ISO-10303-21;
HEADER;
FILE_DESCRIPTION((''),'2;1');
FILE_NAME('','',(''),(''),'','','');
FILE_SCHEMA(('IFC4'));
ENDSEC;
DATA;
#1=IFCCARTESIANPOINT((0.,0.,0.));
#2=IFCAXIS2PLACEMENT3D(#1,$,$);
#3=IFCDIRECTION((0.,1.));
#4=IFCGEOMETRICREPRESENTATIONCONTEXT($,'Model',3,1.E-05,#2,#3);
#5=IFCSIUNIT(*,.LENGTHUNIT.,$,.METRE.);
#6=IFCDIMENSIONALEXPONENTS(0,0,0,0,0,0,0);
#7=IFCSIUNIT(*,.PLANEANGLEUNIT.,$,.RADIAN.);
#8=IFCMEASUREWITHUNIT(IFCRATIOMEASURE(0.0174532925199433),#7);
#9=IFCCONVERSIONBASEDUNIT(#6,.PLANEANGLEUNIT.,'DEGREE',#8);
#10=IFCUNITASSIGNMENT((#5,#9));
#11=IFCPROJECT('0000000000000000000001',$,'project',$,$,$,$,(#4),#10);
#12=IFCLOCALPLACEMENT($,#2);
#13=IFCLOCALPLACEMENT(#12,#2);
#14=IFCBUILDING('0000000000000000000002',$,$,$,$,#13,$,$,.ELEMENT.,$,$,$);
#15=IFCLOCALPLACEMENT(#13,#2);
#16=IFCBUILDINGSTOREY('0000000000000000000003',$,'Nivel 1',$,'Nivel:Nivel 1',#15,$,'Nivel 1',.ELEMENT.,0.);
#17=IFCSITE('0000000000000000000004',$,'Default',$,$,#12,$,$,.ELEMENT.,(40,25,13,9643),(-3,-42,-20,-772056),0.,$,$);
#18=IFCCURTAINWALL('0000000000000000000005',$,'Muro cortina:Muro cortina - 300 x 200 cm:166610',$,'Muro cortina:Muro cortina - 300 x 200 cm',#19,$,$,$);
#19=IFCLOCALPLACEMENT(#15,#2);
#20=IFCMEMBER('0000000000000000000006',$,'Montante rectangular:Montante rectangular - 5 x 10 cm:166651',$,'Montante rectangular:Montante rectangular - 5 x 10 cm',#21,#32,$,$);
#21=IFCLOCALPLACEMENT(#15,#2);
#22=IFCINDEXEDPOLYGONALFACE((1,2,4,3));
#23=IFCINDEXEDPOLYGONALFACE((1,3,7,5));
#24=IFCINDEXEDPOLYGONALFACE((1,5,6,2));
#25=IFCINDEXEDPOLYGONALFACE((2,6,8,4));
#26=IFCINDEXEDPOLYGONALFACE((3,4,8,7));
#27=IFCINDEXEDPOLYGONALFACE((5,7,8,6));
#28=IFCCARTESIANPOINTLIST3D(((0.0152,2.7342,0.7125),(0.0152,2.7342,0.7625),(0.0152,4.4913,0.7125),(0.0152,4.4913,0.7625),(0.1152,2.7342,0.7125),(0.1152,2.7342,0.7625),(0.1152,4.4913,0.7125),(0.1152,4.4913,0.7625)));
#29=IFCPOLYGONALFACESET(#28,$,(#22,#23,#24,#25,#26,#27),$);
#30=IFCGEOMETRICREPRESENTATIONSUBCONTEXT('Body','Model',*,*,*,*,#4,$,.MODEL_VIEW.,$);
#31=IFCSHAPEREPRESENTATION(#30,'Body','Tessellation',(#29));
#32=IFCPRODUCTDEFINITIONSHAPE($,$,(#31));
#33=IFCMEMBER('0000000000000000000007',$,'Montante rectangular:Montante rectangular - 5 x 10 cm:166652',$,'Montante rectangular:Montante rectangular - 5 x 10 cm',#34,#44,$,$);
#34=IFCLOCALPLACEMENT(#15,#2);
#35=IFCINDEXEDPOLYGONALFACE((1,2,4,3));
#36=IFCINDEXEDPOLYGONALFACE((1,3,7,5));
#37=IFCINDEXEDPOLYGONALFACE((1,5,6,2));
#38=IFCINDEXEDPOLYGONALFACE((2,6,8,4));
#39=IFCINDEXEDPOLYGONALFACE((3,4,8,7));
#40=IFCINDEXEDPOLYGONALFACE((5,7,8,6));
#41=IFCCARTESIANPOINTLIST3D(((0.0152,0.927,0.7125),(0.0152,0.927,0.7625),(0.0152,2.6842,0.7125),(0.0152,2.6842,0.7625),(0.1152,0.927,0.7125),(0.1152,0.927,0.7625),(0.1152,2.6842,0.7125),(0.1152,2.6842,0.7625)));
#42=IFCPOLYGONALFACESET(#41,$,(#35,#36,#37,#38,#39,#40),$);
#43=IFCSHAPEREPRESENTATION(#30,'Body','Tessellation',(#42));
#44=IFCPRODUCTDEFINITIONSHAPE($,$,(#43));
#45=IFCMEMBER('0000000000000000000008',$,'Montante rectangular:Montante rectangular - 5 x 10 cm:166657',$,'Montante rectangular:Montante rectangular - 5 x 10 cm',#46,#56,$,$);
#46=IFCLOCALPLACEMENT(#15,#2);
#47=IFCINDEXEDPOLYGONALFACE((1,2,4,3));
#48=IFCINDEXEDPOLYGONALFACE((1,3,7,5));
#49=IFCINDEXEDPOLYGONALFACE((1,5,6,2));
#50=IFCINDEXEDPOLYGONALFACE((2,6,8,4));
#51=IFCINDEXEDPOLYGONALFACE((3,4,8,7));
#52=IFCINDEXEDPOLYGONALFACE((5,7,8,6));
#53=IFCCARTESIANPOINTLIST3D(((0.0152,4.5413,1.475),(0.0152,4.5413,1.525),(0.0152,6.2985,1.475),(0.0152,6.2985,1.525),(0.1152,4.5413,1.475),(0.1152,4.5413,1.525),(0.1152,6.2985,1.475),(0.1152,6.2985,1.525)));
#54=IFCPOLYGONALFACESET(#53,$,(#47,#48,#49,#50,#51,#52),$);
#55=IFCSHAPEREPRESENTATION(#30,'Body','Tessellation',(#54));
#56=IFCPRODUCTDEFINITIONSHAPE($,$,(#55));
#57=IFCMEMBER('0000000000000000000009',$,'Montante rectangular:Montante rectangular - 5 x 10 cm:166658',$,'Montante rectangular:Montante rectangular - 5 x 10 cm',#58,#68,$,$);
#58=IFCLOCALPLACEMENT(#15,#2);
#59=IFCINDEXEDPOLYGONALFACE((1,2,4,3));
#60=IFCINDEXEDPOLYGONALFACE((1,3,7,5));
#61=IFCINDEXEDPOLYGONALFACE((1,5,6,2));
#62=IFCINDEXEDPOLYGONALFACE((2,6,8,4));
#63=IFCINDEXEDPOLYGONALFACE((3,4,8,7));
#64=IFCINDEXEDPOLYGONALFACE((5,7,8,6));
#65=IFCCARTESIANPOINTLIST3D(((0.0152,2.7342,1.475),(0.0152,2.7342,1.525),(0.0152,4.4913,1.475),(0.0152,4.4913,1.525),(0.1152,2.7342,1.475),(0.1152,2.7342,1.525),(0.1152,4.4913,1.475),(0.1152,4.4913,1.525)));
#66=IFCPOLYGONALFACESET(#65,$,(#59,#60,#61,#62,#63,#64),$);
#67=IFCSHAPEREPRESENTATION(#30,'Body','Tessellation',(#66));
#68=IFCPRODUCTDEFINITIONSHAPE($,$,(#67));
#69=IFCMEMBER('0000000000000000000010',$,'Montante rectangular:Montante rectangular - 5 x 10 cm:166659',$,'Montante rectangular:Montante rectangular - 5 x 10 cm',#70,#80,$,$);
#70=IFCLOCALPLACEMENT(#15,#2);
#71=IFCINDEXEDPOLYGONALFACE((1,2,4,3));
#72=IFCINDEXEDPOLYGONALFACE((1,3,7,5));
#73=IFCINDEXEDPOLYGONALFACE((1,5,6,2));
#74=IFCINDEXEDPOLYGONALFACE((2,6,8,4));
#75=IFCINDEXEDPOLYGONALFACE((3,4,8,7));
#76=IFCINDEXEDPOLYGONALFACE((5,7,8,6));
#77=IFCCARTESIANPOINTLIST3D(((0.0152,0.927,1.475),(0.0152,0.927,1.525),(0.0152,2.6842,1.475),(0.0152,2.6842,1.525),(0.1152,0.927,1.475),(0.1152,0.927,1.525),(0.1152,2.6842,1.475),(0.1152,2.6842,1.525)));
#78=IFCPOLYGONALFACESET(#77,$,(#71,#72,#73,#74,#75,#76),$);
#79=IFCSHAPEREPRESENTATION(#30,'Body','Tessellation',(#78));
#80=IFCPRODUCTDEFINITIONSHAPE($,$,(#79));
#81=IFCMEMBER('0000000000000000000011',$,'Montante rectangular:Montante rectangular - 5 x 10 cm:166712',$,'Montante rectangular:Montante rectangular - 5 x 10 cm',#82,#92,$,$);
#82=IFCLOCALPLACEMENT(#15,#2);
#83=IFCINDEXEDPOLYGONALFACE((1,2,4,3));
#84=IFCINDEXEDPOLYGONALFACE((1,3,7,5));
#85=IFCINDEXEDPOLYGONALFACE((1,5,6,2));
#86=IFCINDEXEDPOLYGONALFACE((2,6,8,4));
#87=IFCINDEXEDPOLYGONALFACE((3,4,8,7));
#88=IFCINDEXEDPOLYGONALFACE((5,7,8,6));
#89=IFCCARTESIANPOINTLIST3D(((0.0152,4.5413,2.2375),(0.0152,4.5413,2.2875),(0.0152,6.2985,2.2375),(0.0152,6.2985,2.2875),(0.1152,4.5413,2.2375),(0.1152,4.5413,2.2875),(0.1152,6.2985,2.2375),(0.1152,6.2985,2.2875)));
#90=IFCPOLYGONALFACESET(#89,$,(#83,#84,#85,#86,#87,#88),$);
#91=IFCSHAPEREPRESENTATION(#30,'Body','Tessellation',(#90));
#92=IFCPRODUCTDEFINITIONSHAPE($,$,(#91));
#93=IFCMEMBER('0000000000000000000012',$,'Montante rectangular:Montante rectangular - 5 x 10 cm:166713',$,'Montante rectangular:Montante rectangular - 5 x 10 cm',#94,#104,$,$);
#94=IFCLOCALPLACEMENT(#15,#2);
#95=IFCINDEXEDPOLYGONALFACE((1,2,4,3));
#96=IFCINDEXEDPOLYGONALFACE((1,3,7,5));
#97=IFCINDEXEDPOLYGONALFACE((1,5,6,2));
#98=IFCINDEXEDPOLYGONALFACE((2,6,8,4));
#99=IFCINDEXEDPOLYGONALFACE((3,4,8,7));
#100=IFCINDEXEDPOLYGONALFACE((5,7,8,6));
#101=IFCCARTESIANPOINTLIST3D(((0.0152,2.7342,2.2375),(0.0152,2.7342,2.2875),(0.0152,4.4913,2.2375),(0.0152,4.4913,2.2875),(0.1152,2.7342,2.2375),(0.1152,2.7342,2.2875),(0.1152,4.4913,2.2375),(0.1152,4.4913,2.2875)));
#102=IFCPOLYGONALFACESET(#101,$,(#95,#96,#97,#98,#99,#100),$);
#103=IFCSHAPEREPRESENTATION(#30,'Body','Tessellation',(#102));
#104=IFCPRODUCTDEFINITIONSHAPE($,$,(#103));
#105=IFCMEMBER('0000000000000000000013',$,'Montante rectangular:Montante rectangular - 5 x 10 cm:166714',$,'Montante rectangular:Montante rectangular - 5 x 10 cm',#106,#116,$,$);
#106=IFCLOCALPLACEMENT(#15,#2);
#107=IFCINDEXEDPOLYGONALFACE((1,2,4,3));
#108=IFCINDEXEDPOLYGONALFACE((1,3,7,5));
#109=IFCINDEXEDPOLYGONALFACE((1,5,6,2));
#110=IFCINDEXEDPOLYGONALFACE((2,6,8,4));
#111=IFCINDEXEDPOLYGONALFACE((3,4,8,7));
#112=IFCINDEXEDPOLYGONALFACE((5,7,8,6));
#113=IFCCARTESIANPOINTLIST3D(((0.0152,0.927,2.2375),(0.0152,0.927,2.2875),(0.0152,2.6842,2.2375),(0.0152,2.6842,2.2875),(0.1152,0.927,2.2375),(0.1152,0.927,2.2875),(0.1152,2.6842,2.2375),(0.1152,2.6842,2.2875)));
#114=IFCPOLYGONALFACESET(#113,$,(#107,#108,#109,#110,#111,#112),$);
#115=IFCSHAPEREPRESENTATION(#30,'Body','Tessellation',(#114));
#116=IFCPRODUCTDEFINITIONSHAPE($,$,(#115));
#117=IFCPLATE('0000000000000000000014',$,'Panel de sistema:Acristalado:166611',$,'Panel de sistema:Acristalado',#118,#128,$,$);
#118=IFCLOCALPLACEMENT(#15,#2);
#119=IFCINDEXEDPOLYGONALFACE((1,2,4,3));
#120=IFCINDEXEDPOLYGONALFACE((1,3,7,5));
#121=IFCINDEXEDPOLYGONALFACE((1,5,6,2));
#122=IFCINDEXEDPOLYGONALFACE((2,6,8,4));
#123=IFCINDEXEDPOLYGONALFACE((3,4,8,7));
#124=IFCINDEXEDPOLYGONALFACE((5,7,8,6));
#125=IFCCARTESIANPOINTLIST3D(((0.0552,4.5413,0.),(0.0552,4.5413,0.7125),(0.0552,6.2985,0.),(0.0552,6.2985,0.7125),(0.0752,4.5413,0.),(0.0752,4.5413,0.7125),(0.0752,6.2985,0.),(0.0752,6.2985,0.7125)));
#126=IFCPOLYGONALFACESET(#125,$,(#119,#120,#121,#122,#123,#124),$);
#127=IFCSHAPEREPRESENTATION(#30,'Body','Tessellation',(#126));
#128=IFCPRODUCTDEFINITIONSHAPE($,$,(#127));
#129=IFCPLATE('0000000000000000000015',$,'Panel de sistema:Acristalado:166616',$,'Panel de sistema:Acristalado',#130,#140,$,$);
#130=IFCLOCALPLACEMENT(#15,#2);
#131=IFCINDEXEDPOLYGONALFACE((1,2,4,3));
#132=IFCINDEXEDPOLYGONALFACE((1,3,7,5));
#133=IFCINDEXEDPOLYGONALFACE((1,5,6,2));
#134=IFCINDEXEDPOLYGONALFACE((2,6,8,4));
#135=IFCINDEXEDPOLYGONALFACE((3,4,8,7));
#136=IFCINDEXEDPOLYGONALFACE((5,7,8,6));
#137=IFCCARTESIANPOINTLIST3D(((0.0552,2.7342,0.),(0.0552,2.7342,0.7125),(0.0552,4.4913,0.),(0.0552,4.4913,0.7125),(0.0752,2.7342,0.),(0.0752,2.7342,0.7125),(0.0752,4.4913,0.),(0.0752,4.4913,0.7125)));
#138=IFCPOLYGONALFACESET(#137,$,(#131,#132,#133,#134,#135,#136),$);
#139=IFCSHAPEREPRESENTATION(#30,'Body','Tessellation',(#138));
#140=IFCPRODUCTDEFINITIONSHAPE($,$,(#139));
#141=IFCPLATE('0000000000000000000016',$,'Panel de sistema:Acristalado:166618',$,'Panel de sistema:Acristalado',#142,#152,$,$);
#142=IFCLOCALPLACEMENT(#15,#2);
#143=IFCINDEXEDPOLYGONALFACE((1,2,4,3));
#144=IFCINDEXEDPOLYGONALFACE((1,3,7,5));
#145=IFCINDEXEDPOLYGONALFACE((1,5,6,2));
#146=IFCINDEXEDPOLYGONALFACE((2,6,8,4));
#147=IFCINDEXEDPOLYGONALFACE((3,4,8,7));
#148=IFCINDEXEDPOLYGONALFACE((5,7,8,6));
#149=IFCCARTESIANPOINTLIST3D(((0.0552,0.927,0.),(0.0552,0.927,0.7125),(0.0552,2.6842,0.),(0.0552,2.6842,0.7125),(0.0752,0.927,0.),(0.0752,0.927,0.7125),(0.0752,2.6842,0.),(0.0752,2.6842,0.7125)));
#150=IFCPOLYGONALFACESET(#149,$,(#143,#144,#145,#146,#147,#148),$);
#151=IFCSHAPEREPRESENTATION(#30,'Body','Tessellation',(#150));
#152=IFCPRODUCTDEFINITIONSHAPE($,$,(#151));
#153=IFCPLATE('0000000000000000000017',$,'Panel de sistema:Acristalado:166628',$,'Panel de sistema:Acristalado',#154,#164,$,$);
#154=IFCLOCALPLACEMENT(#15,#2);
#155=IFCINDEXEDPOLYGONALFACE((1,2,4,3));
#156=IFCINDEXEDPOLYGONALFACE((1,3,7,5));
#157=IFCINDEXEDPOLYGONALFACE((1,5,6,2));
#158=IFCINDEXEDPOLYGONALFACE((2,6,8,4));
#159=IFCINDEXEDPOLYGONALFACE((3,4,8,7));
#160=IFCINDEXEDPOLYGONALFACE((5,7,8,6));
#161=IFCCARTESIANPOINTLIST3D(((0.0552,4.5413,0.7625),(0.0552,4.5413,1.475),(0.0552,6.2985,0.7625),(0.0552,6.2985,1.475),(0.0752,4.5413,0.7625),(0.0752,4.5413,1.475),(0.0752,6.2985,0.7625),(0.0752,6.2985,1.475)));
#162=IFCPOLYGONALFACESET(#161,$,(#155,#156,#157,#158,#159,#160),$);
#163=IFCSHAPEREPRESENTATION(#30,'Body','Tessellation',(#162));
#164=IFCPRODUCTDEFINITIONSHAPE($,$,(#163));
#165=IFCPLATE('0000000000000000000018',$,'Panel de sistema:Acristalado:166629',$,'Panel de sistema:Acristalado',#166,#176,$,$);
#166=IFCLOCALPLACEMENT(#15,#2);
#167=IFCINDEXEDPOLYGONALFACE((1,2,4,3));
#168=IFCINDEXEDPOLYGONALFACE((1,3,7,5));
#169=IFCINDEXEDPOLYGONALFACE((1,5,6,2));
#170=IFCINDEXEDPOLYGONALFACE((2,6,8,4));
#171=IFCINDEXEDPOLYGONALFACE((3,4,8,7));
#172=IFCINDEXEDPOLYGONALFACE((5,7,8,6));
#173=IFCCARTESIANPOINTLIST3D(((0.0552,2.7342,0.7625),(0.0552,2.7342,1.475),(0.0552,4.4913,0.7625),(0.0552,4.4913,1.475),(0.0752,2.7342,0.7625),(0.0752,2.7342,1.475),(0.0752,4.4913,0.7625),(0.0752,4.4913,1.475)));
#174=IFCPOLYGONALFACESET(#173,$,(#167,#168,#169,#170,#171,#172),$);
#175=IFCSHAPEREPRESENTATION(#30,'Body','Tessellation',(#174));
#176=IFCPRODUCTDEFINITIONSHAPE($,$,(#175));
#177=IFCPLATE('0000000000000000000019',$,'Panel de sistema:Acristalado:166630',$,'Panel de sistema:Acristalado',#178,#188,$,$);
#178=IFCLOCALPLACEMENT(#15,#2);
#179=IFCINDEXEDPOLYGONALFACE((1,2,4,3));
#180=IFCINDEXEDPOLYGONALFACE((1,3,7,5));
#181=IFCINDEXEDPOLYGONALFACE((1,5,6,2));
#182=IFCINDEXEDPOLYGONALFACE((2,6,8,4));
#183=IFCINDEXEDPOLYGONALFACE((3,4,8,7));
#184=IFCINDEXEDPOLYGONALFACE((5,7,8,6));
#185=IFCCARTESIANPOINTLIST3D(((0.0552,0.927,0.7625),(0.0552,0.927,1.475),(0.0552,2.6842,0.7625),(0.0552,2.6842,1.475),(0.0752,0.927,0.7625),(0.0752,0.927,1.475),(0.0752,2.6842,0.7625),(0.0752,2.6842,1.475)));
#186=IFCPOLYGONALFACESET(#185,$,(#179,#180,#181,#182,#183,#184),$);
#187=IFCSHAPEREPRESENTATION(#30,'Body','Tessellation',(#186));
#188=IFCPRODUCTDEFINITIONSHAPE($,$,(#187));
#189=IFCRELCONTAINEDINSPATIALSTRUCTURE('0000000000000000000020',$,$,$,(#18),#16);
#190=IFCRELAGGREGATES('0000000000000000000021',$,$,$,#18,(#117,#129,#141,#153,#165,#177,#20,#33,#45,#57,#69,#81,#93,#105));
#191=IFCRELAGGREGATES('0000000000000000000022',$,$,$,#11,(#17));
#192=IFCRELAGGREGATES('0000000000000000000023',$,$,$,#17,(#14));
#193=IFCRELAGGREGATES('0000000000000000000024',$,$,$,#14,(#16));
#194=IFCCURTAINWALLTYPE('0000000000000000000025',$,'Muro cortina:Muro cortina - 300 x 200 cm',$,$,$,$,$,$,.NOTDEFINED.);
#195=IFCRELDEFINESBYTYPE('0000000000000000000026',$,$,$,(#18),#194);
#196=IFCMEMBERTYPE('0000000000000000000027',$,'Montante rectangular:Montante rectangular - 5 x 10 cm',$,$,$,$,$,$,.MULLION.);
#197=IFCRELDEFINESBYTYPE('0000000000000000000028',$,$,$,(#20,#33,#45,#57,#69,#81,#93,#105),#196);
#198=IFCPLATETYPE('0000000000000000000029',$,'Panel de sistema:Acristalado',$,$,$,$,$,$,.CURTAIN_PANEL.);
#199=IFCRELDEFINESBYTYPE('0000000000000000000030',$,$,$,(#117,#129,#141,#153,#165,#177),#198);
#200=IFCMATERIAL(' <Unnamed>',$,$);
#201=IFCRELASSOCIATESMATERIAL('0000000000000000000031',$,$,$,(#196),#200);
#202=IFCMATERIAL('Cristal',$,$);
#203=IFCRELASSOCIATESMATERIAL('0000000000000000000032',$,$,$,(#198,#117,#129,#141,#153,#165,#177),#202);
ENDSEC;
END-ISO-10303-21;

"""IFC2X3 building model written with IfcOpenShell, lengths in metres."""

from ifc_helpers import new_model, entity, si_unit, converted_unit, direction, frame, origin, origin_2d_with_axis, place, context, subcontext, project, spatial, rectangle, extrude, source, transform, mapped, material, type_object, type_shapes, element, aggregate, save


model = new_model("IFC2X3")

# Units and contexts
model_context = context("Model", 3, precision=1e-05, world=origin(), true_north=direction((0.0, 1.0)))
body_context = subcontext(model_context, "Body", "Model", "MODEL_VIEW")
ifc_project = project(units=[si_unit("LENGTHUNIT", "METRE"), converted_unit("PLANEANGLEUNIT", "DEGREE", entity("IfcRatioMeasure", 0.0174532925199433), si_unit("PLANEANGLEUNIT", "RADIAN"), dimensions=[0, 0, 0, 0, 0, 0, 0])], contexts=[model_context])

# Site, building, storey
site_placement = place(None, origin())
site = spatial("IfcSite", under=ifc_project, at=site_placement, Name="Default", CompositionType="ELEMENT", RefLatitude=(40, 25, 13, 9643), RefLongitude=(-3, -42, -20, -772056), RefElevation=0.0)
building_placement = place(site_placement, origin())
building = spatial("IfcBuilding", under=site, at=building_placement, CompositionType="ELEMENT")
storey_placement = place(building_placement, origin())
storey = spatial("IfcBuildingStorey", under=building, at=storey_placement, Name="Nivel 1", ObjectType="Nivel:Nivel 1", LongName="Nivel 1", CompositionType="ELEMENT", Elevation=0.0)

# Curtain wall, members, plates
curtain_wall_type = type_object("IfcCurtainWallType", Name="Muro cortina:Muro cortina - 300 x 200 cm", PredefinedType="NOTDEFINED")
curtain_wall_placement = place(storey_placement, origin())
curtain_wall = element("IfcCurtainWall", 1, at=curtain_wall_placement, inside=storey, type_object=curtain_wall_type, Name="Muro cortina:Muro cortina - 300 x 200 cm:166610", ObjectType="Muro cortina:Muro cortina - 300 x 200 cm")
ifc_material_1 = material(Name=" <Unnamed>")
member_type_1 = type_object("IfcMemberType", Name="Montante rectangular:Montante rectangular - 5 x 10 cm", PredefinedType="MULLION", material=ifc_material_1)
shared_shape_1 = source(origin(), body_context, "Body", "SweptSolid", [
    extrude(rectangle(XDim=0.1, YDim=0.05, at=origin_2d_with_axis()), frame((0.0, 0.0, -1.7571), z_axis=(0.0, 0.0, 1.0), x_axis=(0.0, -1.0, 0.0)), (0.0, 0.0, 1.0), 1.7571),
])
type_shapes(member_type_1, [shared_shape_1])
member_1_placement = place(storey_placement, frame((0.0652, 2.7342, 0.7375), z_axis=(0.0, -1.0, 0.0), x_axis=(0.0, 0.0, 1.0)))
member_1 = element("IfcMember", 2, at=member_1_placement, type_object=member_type_1, Name="Montante rectangular:Montante rectangular - 5 x 10 cm:166651", ObjectType="Montante rectangular:Montante rectangular - 5 x 10 cm", context=body_context, shape_type="MappedRepresentation", body=[
    mapped(shared_shape_1, transform((0.0, 0.0, 0.0), scale=1.0)),
])
member_2_placement = place(storey_placement, frame((0.0652, 0.927, 0.7375), z_axis=(0.0, -1.0, 0.0), x_axis=(0.0, 0.0, 1.0)))
member_2 = element("IfcMember", 3, at=member_2_placement, type_object=member_type_1, Name="Montante rectangular:Montante rectangular - 5 x 10 cm:166652", ObjectType="Montante rectangular:Montante rectangular - 5 x 10 cm", context=body_context, shape_type="MappedRepresentation", body=[
    mapped(shared_shape_1, transform((0.0, 0.0, 0.0), scale=1.0)),
])
member_3_placement = place(storey_placement, frame((0.0652, 4.5413, 1.5), z_axis=(0.0, -1.0, 0.0), x_axis=(0.0, 0.0, 1.0)))
member_3 = element("IfcMember", 4, at=member_3_placement, type_object=member_type_1, Name="Montante rectangular:Montante rectangular - 5 x 10 cm:166657", ObjectType="Montante rectangular:Montante rectangular - 5 x 10 cm", context=body_context, shape_type="MappedRepresentation", body=[
    mapped(shared_shape_1, transform((0.0, 0.0, 0.0), scale=1.0)),
])
member_4_placement = place(storey_placement, frame((0.0652, 2.7342, 1.5), z_axis=(0.0, -1.0, 0.0), x_axis=(0.0, 0.0, 1.0)))
member_4 = element("IfcMember", 5, at=member_4_placement, type_object=member_type_1, Name="Montante rectangular:Montante rectangular - 5 x 10 cm:166658", ObjectType="Montante rectangular:Montante rectangular - 5 x 10 cm", context=body_context, shape_type="MappedRepresentation", body=[
    mapped(shared_shape_1, transform((0.0, 0.0, 0.0), scale=1.0)),
])
member_5_placement = place(storey_placement, frame((0.0652, 0.927, 1.5), z_axis=(0.0, -1.0, 0.0), x_axis=(0.0, 0.0, 1.0)))
member_5 = element("IfcMember", 6, at=member_5_placement, type_object=member_type_1, Name="Montante rectangular:Montante rectangular - 5 x 10 cm:166659", ObjectType="Montante rectangular:Montante rectangular - 5 x 10 cm", context=body_context, shape_type="MappedRepresentation", body=[
    mapped(shared_shape_1, transform((0.0, 0.0, 0.0), scale=1.0)),
])
member_6_placement = place(storey_placement, frame((0.0652, 4.5413, 2.2625), z_axis=(0.0, -1.0, 0.0), x_axis=(0.0, 0.0, 1.0)))
member_6 = element("IfcMember", 7, at=member_6_placement, type_object=member_type_1, Name="Montante rectangular:Montante rectangular - 5 x 10 cm:166712", ObjectType="Montante rectangular:Montante rectangular - 5 x 10 cm", context=body_context, shape_type="MappedRepresentation", body=[
    mapped(shared_shape_1, transform((0.0, 0.0, 0.0), scale=1.0)),
])
member_7_placement = place(storey_placement, frame((0.0652, 2.7342, 2.2625), z_axis=(0.0, -1.0, 0.0), x_axis=(0.0, 0.0, 1.0)))
member_7 = element("IfcMember", 8, at=member_7_placement, type_object=member_type_1, Name="Montante rectangular:Montante rectangular - 5 x 10 cm:166713", ObjectType="Montante rectangular:Montante rectangular - 5 x 10 cm", context=body_context, shape_type="MappedRepresentation", body=[
    mapped(shared_shape_1, transform((0.0, 0.0, 0.0), scale=1.0)),
])
member_8_placement = place(storey_placement, frame((0.0652, 0.927, 2.2625), z_axis=(0.0, -1.0, 0.0), x_axis=(0.0, 0.0, 1.0)))
member_8 = element("IfcMember", 9, at=member_8_placement, type_object=member_type_1, Name="Montante rectangular:Montante rectangular - 5 x 10 cm:166714", ObjectType="Montante rectangular:Montante rectangular - 5 x 10 cm", context=body_context, shape_type="MappedRepresentation", body=[
    mapped(shared_shape_1, transform((0.0, 0.0, 0.0), scale=1.0)),
])
ifc_material_2 = material(Name="Cristal")
plate_type = type_object("IfcPlateType", Name="Panel de sistema:Acristalado", PredefinedType="CURTAIN_PANEL", material=ifc_material_2)
shared_shape_2 = source(origin(), body_context, "Body", "SweptSolid", [
    extrude(rectangle(XDim=0.02, YDim=1.7571, at=origin_2d_with_axis()), frame((0.0, 0.0, 0.0), z_axis=(0.0, 0.0, 1.0), x_axis=(0.0, 1.0, 0.0)), (0.0, 0.0, 1.0), 0.7125),
])
type_shapes(plate_type, [shared_shape_2])
plate_1_placement = place(curtain_wall_placement, frame((0.0652, 5.4199, 0.0), z_axis=(0.0, 0.0, 1.0), x_axis=(0.0, -1.0, 0.0)))
plate_1 = element("IfcPlate", 10, at=plate_1_placement, type_object=plate_type, material=ifc_material_2, Name="Panel de sistema:Acristalado:166611", ObjectType="Panel de sistema:Acristalado", context=body_context, shape_type="MappedRepresentation", body=[
    mapped(shared_shape_2, transform((0.0, 0.0, 0.0), scale=1.0)),
])
plate_2_placement = place(curtain_wall_placement, frame((0.0652, 3.6127, 0.0), z_axis=(0.0, 0.0, 1.0), x_axis=(0.0, -1.0, 0.0)))
plate_2 = element("IfcPlate", 11, at=plate_2_placement, type_object=plate_type, material=ifc_material_2, Name="Panel de sistema:Acristalado:166616", ObjectType="Panel de sistema:Acristalado", context=body_context, shape_type="MappedRepresentation", body=[
    mapped(shared_shape_2, transform((0.0, 0.0, 0.0), scale=1.0)),
])
plate_3_placement = place(curtain_wall_placement, frame((0.0652, 1.8056, 0.0), z_axis=(0.0, 0.0, 1.0), x_axis=(0.0, -1.0, 0.0)))
plate_3 = element("IfcPlate", 12, at=plate_3_placement, type_object=plate_type, material=ifc_material_2, Name="Panel de sistema:Acristalado:166618", ObjectType="Panel de sistema:Acristalado", context=body_context, shape_type="MappedRepresentation", body=[
    mapped(shared_shape_2, transform((0.0, 0.0, 0.0), scale=1.0)),
])
plate_4_placement = place(curtain_wall_placement, frame((0.0652, 5.4199, 0.7625), z_axis=(0.0, 0.0, 1.0), x_axis=(0.0, -1.0, 0.0)))
plate_4 = element("IfcPlate", 13, at=plate_4_placement, type_object=plate_type, material=ifc_material_2, Name="Panel de sistema:Acristalado:166628", ObjectType="Panel de sistema:Acristalado", context=body_context, shape_type="MappedRepresentation", body=[
    mapped(shared_shape_2, transform((0.0, 0.0, 0.0), scale=1.0)),
])
plate_5_placement = place(curtain_wall_placement, frame((0.0652, 3.6127, 0.7625), z_axis=(0.0, 0.0, 1.0), x_axis=(0.0, -1.0, 0.0)))
plate_5 = element("IfcPlate", 14, at=plate_5_placement, type_object=plate_type, material=ifc_material_2, Name="Panel de sistema:Acristalado:166629", ObjectType="Panel de sistema:Acristalado", context=body_context, shape_type="MappedRepresentation", body=[
    mapped(shared_shape_2, transform((0.0, 0.0, 0.0), scale=1.0)),
])
plate_6_placement = place(curtain_wall_placement, frame((0.0652, 1.8056, 0.7625), z_axis=(0.0, 0.0, 1.0), x_axis=(0.0, -1.0, 0.0)))
plate_6 = element("IfcPlate", 15, at=plate_6_placement, type_object=plate_type, material=ifc_material_2, Name="Panel de sistema:Acristalado:166630", ObjectType="Panel de sistema:Acristalado", context=body_context, shape_type="MappedRepresentation", body=[
    mapped(shared_shape_2, transform((0.0, 0.0, 0.0), scale=1.0)),
])
aggregate(curtain_wall, [plate_1, plate_2, plate_3, plate_4, plate_5, plate_6, member_1, member_2, member_3, member_4, member_5, member_6, member_7, member_8])

save(model, "model.ifc")
